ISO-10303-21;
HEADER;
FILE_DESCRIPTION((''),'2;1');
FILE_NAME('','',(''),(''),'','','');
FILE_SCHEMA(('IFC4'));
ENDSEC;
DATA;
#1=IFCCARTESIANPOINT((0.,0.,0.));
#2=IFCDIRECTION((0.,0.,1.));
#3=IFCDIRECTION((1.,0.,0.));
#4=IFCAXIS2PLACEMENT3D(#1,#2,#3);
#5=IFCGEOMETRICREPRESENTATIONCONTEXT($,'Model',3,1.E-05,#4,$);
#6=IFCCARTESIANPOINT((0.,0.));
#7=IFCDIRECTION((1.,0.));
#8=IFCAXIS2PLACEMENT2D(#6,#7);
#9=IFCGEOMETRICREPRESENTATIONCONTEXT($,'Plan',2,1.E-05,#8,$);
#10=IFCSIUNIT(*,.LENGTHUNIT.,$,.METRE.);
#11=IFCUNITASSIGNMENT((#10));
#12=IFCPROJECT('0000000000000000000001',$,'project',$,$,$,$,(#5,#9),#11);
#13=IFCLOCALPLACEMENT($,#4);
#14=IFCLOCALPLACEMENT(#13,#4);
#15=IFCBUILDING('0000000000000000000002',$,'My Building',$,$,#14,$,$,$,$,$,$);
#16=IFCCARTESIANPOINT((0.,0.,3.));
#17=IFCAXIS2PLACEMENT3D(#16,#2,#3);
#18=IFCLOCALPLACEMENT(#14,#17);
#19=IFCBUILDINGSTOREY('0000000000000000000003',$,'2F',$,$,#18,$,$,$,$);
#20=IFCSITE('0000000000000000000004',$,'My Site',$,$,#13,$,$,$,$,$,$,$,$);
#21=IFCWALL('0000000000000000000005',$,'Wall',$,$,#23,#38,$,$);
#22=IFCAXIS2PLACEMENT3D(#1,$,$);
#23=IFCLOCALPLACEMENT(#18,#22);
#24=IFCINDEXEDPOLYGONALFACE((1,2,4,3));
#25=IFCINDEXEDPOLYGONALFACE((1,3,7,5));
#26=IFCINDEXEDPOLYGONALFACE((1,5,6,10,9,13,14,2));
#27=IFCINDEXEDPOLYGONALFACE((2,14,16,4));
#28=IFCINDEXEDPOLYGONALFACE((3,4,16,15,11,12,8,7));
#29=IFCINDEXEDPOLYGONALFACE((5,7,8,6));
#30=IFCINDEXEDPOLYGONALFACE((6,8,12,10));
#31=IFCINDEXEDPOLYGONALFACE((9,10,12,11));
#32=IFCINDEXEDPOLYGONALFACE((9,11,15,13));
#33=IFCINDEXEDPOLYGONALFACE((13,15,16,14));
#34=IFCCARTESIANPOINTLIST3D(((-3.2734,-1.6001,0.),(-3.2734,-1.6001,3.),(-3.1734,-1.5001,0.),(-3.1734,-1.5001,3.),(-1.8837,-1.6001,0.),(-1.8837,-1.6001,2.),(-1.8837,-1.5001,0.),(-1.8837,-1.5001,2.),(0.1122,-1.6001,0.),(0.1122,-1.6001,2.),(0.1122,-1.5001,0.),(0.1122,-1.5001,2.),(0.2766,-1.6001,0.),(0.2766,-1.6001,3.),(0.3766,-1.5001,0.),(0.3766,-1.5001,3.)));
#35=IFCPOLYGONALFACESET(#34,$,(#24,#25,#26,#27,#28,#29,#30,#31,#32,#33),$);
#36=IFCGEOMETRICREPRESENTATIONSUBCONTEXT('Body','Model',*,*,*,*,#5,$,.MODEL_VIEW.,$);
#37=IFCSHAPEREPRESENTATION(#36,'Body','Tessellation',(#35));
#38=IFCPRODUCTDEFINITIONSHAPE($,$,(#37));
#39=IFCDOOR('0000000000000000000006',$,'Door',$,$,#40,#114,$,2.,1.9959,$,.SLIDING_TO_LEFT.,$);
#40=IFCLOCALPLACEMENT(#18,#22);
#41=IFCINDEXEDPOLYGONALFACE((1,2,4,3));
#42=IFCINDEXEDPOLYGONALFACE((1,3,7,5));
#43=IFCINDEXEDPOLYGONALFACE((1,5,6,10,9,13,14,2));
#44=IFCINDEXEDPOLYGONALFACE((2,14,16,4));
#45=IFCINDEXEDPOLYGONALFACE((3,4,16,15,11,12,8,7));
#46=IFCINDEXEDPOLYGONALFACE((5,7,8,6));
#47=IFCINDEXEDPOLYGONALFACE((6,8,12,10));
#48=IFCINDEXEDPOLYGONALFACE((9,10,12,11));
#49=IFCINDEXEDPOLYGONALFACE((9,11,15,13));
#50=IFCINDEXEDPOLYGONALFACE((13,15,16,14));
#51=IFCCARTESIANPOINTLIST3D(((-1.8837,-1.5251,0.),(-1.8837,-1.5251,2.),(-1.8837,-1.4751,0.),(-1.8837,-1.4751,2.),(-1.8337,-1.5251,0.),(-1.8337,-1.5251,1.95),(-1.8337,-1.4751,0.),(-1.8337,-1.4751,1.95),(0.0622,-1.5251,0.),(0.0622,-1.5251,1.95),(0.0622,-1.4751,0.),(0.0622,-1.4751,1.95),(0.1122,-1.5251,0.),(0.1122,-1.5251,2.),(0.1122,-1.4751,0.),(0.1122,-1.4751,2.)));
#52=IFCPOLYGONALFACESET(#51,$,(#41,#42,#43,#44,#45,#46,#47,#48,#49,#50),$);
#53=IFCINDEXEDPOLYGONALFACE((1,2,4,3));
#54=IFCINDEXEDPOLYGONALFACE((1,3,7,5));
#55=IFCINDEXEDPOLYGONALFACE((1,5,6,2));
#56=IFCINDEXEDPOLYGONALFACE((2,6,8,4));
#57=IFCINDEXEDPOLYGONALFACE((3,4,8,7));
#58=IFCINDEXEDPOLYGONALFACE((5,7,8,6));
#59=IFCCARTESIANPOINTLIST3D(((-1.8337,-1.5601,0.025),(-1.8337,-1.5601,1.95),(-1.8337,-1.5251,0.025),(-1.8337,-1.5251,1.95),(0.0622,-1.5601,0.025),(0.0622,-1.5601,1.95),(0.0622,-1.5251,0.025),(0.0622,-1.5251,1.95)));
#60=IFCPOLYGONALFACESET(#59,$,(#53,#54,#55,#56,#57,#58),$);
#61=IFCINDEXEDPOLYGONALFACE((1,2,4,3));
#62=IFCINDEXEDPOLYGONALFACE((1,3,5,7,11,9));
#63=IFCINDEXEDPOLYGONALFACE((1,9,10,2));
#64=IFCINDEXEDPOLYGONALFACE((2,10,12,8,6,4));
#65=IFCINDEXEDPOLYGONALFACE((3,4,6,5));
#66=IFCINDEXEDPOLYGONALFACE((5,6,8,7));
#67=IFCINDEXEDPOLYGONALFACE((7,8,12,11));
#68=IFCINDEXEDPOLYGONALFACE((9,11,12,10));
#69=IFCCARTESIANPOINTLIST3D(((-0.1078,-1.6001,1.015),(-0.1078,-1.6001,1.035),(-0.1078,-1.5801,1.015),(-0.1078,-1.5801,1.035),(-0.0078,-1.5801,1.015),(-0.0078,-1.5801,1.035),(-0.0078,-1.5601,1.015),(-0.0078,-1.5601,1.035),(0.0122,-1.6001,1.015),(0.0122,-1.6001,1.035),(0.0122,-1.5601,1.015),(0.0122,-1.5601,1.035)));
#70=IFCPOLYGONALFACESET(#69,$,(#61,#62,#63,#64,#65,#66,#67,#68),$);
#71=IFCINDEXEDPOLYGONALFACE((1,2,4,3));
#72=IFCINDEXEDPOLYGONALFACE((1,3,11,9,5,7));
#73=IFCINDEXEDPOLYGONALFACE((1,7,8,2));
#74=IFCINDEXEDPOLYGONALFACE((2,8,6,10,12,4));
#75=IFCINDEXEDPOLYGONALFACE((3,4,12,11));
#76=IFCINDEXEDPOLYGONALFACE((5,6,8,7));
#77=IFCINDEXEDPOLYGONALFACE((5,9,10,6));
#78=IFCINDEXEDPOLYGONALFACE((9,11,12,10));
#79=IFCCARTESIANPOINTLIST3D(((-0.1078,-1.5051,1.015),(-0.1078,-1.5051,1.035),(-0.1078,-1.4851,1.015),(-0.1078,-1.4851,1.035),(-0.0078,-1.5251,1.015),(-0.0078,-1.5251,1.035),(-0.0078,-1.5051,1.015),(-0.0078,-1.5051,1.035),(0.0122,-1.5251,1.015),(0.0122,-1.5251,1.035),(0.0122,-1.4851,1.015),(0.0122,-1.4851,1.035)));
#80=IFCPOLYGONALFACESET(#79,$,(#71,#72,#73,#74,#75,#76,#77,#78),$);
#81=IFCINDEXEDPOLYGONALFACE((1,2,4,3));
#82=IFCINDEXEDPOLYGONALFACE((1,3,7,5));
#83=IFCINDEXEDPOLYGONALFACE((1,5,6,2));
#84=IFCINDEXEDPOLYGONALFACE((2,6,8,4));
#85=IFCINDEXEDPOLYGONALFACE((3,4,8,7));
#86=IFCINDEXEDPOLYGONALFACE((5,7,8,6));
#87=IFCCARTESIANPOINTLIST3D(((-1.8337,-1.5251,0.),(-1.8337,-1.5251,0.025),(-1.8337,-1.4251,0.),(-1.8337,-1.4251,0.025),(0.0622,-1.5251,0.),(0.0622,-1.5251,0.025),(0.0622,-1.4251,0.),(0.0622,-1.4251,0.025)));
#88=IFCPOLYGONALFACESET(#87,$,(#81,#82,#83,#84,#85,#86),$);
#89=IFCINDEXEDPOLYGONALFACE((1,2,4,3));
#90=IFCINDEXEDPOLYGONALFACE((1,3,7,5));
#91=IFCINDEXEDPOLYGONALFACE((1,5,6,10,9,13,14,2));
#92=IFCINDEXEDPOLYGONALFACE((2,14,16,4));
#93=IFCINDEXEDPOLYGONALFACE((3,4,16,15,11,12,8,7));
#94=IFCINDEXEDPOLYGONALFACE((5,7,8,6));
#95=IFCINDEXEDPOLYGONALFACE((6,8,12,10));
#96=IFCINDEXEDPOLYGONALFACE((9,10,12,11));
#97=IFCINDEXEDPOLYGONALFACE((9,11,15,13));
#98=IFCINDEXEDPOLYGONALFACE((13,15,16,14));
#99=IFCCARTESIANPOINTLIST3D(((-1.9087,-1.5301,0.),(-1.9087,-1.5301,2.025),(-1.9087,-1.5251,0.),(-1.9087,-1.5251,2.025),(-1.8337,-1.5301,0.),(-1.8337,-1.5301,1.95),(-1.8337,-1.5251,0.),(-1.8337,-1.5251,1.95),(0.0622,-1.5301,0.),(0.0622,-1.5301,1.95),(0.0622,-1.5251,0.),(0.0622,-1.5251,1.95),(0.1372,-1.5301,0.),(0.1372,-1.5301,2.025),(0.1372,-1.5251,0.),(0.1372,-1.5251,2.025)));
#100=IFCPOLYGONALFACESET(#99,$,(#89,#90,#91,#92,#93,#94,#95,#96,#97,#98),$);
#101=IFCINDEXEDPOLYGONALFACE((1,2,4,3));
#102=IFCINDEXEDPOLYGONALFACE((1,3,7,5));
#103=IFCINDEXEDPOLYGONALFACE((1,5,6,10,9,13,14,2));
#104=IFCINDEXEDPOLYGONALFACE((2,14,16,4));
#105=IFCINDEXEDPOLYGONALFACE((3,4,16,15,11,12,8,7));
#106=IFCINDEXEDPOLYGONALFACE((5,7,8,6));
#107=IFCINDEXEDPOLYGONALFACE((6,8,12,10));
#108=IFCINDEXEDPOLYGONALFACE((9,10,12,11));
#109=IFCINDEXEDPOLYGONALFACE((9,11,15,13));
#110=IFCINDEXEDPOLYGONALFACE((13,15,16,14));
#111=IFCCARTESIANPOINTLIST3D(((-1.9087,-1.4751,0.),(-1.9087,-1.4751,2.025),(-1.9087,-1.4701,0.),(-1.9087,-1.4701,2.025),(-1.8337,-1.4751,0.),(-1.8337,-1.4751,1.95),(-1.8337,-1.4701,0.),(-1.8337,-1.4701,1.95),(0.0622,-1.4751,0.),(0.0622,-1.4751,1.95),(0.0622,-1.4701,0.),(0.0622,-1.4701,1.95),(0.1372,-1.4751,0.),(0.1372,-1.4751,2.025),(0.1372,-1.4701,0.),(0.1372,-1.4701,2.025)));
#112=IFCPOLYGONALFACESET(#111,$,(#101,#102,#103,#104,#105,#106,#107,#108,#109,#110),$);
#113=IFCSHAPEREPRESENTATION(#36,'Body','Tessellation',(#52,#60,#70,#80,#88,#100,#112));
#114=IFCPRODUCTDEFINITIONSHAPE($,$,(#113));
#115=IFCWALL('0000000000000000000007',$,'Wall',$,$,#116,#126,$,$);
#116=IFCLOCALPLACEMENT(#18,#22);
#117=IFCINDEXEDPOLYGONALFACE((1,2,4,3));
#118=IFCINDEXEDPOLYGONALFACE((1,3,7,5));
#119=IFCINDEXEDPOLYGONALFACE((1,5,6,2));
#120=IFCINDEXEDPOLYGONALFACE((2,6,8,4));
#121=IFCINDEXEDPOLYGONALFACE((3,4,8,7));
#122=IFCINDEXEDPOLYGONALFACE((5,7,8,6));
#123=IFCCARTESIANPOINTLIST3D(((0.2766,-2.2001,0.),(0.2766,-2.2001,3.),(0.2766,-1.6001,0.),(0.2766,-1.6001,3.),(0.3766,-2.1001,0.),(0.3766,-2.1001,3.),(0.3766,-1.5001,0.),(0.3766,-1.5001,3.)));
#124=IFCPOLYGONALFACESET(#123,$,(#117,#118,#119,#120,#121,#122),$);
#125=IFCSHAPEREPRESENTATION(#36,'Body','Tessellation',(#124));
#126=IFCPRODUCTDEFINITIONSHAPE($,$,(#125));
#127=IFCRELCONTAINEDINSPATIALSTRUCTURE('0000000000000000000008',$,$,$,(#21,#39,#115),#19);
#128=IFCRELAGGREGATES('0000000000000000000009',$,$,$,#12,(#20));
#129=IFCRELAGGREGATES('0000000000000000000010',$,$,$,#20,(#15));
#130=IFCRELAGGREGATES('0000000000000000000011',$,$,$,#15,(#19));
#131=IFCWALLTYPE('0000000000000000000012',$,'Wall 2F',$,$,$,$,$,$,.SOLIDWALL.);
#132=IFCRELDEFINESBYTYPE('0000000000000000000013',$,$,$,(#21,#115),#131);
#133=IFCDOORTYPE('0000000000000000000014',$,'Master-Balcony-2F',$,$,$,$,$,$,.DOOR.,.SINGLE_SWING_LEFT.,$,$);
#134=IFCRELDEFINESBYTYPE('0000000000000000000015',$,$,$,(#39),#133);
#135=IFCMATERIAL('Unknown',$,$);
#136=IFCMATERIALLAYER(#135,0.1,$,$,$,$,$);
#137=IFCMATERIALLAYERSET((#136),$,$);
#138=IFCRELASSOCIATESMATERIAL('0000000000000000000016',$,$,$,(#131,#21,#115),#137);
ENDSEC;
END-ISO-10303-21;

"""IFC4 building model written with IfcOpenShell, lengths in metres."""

from ifc_helpers import new_model, entity, si_unit, frame, origin_with_axes, origin_2d_with_axis, place, context, subcontext, project, spatial, line, indexed_curve, outline, extrude, shape, source, transform, mapped, material, layer, layer_set, layer_usage, type_object, type_shapes, element, fill, save


model = new_model("IFC4")

# Units and contexts
model_context = context("Model", 3, precision=1e-05, world=origin_with_axes())
plan_context = context("Plan", 2, precision=1e-05, world=origin_2d_with_axis())
body_context_1 = subcontext(model_context, "Body", "Model", "MODEL_VIEW")
body_context_2 = subcontext(plan_context, "Body", "Plan", "PLAN_VIEW")
ifc_project = project(units=[si_unit("LENGTHUNIT", "METRE")], contexts=[model_context, plan_context])

# Site, building, storey
site_placement = place(None, origin_with_axes())
site = spatial("IfcSite", under=ifc_project, at=site_placement, Name="My Site")
building_placement = place(site_placement, origin_with_axes())
building = spatial("IfcBuilding", under=site, at=building_placement, Name="My Building")
storey_placement = place(building_placement, frame((0.0, 0.0, 3.0), z_axis=(0.0, 0.0, 1.0), x_axis=(1.0, 0.0, 0.0)))
storey = spatial("IfcBuildingStorey", under=building, at=storey_placement, Name="2F")

# Shared definitions
ifc_material = material(Name="Unknown")
ifc_layer_1 = layer(ifc_material, 0.1)
ifc_layer_set_1 = layer_set([ifc_layer_1])
wall_type_1 = type_object("IfcWallType", Name="Wall 2F", PredefinedType="SOLIDWALL", material=ifc_layer_set_1)

# Wall, opening, door
ifc_layer_usage_1 = layer_usage(ifc_layer_set_1, "AXIS2", "POSITIVE", 0.0)
wall_1_placement = place(storey_placement, frame((-3.2734, -1.6001, 0.0), z_axis=(0.0, 0.0, 1.0), x_axis=(1.0, 0.0, 0.0)))
wall_1 = element("IfcWall", 1, at=wall_1_placement, inside=storey, type_object=wall_type_1, material=ifc_layer_usage_1, Name="Wall", context=body_context_1, shape_type="SweptSolid", body=[
    extrude(outline(indexed_curve([(0.0, 0.0), (0.1, 0.1), (3.65, 0.1), (3.55, 0.0)], segments=[line(1, 2, 3, 4, 1)])), origin_with_axes(), (0.0, 0.0, 1.0), 3.0),
])
shared_shape_1 = source(origin_with_axes(), body_context_1, "Body", "SweptSolid", [
    extrude(outline(indexed_curve([(0.0, 0.0), (1.9959, 0.0), (1.9959, 2.0), (0.0, 2.0)], segments=[line(1, 2, 3, 4, 1)])), frame((0.0, -0.6, 0.0), z_axis=(0.0, -1.0, 0.0), x_axis=(1.0, 0.0, 0.0)), (0.0, 0.0, -1.0), 1.2),
])
opening_1_placement = place(wall_1_placement, frame((1.3897, 0.075, 0.0), z_axis=(0.0, 0.0, 1.0), x_axis=(1.0, 0.0, 0.0)))
opening_1 = element("IfcOpeningElement", 2, at=opening_1_placement, cuts=wall_1, PredefinedType="OPENING", context=body_context_1, shape_type="MappedRepresentation", body=[
    mapped(shared_shape_1, transform((0.0, 0.0, 0.0), x_axis=(1.0, 0.0, 0.0), y_axis=(0.0, 1.0, 0.0), z_axis=(0.0, 0.0, 1.0), scale=1.0)),
])
door_type_1 = type_object("IfcDoorType", Name="Master-Balcony-2F", OperationType="SINGLE_SWING_LEFT", PredefinedType="DOOR")
shared_shape_2 = source(origin_with_axes(), body_context_1, "Body", "SweptSolid", [
    extrude(outline(indexed_curve([(0.0, 0.0), (0.0, 2.0), (1.9959, 2.0), (1.9959, 0.0), (1.9459, 0.0), (1.9459, 1.95), (0.05, 1.95), (0.05, 0.0)], segments=[line(1, 2, 3, 4, 5, 6, 7, 8, 1)])), frame((0.0, 0.0, 0.0), z_axis=(0.0, -1.0, 0.0), x_axis=(1.0, 0.0, 0.0)), (0.0, 0.0, -1.0), 0.05),
    extrude(outline(indexed_curve([(0.0, 0.0), (1.8959, 0.0), (1.8959, 0.035), (0.0, 0.035)], segments=[line(1, 2, 3, 4, 1)])), frame((0.05, -0.035, 0.025), z_axis=(0.0, 0.0, 1.0), x_axis=(1.0, 0.0, 0.0)), (0.0, 0.0, 1.0), 1.925),
    extrude(outline(indexed_curve([(0.0, 0.0), (0.0, -0.04), (-0.12, -0.04), (-0.12, -0.02), (-0.02, -0.02), (-0.02, 0.0)], segments=[line(1, 2, 3, 4, 5, 6, 1)])), frame((1.8959, -0.035, 1.015), z_axis=(0.0, 0.0, 1.0), x_axis=(1.0, 0.0, 0.0)), (0.0, 0.0, 1.0), 0.02),
    extrude(outline(indexed_curve([(0.0, 0.0), (0.0, 0.04), (-0.12, 0.04), (-0.12, 0.02), (-0.02, 0.02), (-0.02, 0.0)], segments=[line(1, 2, 3, 4, 5, 6, 1)])), frame((1.8959, 0.0, 1.015), z_axis=(0.0, 0.0, 1.0), x_axis=(1.0, 0.0, 0.0)), (0.0, 0.0, 1.0), 0.02),
    extrude(outline(indexed_curve([(0.0, 0.0), (1.8959, 0.0), (1.8959, 0.1), (0.0, 0.1)], segments=[line(1, 2, 3, 4, 1)])), frame((0.05, 0.0, 0.0), z_axis=(0.0, 0.0, 1.0), x_axis=(1.0, 0.0, 0.0)), (0.0, 0.0, 1.0), 0.025),
    extrude(outline(indexed_curve([(0.0, 0.0), (0.0, 2.025), (2.0459, 2.025), (2.0459, 0.0), (1.9709, 0.0), (1.9709, 1.95), (0.075, 1.95), (0.075, 0.0)], segments=[line(1, 2, 3, 4, 5, 6, 7, 8, 1)])), frame((-0.025, -0.005, 0.0), z_axis=(0.0, -1.0, 0.0), x_axis=(1.0, 0.0, 0.0)), (0.0, 0.0, -1.0), 0.005),
    extrude(outline(indexed_curve([(0.0, 0.0), (0.0, 2.025), (2.0459, 2.025), (2.0459, 0.0), (1.9709, 0.0), (1.9709, 1.95), (0.075, 1.95), (0.075, 0.0)], segments=[line(1, 2, 3, 4, 5, 6, 7, 8, 1)])), frame((-0.025, 0.05, 0.0), z_axis=(0.0, -1.0, 0.0), x_axis=(1.0, 0.0, 0.0)), (0.0, 0.0, -1.0), 0.005),
])
shared_shape_3 = source(origin_with_axes(), body_context_2, "Body", "Curve2D", [
    entity("IfcIndexedPolyCurve", entity("IfcCartesianPointList2D", [[0.0, 0.0], [0.05, 0.0], [0.05, 0.05], [0.0, 0.05]]), [entity("IfcLineIndex", [1, 2, 3, 4, 1])]),
    entity("IfcIndexedPolyCurve", entity("IfcCartesianPointList2D", [[1.9959, 0.0], [1.9459, 0.0], [1.9459, 0.05], [1.9959, 0.05]]), [entity("IfcLineIndex", [1, 2, 3, 4, 1])]),
    entity("IfcIndexedPolyCurve", entity("IfcCartesianPointList2D", [[-0.8979, -0.035], [0.9979, -0.035], [0.9979, 0.0], [-0.8979, 0.0]]), [entity("IfcLineIndex", [1, 2, 3, 4, 1])]),
])
type_shapes(door_type_1, [shared_shape_2, shared_shape_3])
door_1_placement = place(opening_1_placement, frame((0.0, 0.0, 0.0), z_axis=(0.0, 0.0, 1.0), x_axis=(1.0, 0.0, 0.0)))
door_1 = element("IfcDoor", 3, at=door_1_placement, inside=storey, type_object=door_type_1, Name="Door", OperationType="SLIDING_TO_LEFT", OverallHeight=2.0, OverallWidth=1.9959, shapes=[
    shape(body_context_1, "Body", "MappedRepresentation", [mapped(shared_shape_2, transform((0.0, 0.0, 0.0), x_axis=(1.0, 0.0, 0.0), y_axis=(0.0, 1.0, 0.0), z_axis=(0.0, 0.0, 1.0), scale=1.0))]),
    shape(body_context_2, "Body", "MappedRepresentation", [mapped(shared_shape_3, transform((0.0, 0.0, 0.0), x_axis=(1.0, 0.0, 0.0), y_axis=(0.0, 1.0, 0.0), z_axis=(0.0, 0.0, 1.0), scale=1.0))]),
])
fill(opening_1, door_1)

# Wall
ifc_layer_usage_2 = layer_usage(ifc_layer_set_1, "AXIS2", "POSITIVE", 0.0)
wall_2_placement = place(storey_placement, frame((0.2766, -1.6001, 0.0), z_axis=(0.0, 0.0, 1.0), x_axis=(0.0, -1.0, 0.0)))
element("IfcWall", 4, at=wall_2_placement, inside=storey, type_object=wall_type_1, material=ifc_layer_usage_2, Name="Wall", context=body_context_1, shape_type="SweptSolid", body=[
    extrude(outline(indexed_curve([(0.0, 0.0), (-0.1, 0.1), (0.5, 0.1), (0.6, 0.0)], segments=[line(1, 2, 3, 4, 1)])), origin_with_axes(), (0.0, 0.0, 1.0), 3.0),
])

save(model, "model.ifc")
